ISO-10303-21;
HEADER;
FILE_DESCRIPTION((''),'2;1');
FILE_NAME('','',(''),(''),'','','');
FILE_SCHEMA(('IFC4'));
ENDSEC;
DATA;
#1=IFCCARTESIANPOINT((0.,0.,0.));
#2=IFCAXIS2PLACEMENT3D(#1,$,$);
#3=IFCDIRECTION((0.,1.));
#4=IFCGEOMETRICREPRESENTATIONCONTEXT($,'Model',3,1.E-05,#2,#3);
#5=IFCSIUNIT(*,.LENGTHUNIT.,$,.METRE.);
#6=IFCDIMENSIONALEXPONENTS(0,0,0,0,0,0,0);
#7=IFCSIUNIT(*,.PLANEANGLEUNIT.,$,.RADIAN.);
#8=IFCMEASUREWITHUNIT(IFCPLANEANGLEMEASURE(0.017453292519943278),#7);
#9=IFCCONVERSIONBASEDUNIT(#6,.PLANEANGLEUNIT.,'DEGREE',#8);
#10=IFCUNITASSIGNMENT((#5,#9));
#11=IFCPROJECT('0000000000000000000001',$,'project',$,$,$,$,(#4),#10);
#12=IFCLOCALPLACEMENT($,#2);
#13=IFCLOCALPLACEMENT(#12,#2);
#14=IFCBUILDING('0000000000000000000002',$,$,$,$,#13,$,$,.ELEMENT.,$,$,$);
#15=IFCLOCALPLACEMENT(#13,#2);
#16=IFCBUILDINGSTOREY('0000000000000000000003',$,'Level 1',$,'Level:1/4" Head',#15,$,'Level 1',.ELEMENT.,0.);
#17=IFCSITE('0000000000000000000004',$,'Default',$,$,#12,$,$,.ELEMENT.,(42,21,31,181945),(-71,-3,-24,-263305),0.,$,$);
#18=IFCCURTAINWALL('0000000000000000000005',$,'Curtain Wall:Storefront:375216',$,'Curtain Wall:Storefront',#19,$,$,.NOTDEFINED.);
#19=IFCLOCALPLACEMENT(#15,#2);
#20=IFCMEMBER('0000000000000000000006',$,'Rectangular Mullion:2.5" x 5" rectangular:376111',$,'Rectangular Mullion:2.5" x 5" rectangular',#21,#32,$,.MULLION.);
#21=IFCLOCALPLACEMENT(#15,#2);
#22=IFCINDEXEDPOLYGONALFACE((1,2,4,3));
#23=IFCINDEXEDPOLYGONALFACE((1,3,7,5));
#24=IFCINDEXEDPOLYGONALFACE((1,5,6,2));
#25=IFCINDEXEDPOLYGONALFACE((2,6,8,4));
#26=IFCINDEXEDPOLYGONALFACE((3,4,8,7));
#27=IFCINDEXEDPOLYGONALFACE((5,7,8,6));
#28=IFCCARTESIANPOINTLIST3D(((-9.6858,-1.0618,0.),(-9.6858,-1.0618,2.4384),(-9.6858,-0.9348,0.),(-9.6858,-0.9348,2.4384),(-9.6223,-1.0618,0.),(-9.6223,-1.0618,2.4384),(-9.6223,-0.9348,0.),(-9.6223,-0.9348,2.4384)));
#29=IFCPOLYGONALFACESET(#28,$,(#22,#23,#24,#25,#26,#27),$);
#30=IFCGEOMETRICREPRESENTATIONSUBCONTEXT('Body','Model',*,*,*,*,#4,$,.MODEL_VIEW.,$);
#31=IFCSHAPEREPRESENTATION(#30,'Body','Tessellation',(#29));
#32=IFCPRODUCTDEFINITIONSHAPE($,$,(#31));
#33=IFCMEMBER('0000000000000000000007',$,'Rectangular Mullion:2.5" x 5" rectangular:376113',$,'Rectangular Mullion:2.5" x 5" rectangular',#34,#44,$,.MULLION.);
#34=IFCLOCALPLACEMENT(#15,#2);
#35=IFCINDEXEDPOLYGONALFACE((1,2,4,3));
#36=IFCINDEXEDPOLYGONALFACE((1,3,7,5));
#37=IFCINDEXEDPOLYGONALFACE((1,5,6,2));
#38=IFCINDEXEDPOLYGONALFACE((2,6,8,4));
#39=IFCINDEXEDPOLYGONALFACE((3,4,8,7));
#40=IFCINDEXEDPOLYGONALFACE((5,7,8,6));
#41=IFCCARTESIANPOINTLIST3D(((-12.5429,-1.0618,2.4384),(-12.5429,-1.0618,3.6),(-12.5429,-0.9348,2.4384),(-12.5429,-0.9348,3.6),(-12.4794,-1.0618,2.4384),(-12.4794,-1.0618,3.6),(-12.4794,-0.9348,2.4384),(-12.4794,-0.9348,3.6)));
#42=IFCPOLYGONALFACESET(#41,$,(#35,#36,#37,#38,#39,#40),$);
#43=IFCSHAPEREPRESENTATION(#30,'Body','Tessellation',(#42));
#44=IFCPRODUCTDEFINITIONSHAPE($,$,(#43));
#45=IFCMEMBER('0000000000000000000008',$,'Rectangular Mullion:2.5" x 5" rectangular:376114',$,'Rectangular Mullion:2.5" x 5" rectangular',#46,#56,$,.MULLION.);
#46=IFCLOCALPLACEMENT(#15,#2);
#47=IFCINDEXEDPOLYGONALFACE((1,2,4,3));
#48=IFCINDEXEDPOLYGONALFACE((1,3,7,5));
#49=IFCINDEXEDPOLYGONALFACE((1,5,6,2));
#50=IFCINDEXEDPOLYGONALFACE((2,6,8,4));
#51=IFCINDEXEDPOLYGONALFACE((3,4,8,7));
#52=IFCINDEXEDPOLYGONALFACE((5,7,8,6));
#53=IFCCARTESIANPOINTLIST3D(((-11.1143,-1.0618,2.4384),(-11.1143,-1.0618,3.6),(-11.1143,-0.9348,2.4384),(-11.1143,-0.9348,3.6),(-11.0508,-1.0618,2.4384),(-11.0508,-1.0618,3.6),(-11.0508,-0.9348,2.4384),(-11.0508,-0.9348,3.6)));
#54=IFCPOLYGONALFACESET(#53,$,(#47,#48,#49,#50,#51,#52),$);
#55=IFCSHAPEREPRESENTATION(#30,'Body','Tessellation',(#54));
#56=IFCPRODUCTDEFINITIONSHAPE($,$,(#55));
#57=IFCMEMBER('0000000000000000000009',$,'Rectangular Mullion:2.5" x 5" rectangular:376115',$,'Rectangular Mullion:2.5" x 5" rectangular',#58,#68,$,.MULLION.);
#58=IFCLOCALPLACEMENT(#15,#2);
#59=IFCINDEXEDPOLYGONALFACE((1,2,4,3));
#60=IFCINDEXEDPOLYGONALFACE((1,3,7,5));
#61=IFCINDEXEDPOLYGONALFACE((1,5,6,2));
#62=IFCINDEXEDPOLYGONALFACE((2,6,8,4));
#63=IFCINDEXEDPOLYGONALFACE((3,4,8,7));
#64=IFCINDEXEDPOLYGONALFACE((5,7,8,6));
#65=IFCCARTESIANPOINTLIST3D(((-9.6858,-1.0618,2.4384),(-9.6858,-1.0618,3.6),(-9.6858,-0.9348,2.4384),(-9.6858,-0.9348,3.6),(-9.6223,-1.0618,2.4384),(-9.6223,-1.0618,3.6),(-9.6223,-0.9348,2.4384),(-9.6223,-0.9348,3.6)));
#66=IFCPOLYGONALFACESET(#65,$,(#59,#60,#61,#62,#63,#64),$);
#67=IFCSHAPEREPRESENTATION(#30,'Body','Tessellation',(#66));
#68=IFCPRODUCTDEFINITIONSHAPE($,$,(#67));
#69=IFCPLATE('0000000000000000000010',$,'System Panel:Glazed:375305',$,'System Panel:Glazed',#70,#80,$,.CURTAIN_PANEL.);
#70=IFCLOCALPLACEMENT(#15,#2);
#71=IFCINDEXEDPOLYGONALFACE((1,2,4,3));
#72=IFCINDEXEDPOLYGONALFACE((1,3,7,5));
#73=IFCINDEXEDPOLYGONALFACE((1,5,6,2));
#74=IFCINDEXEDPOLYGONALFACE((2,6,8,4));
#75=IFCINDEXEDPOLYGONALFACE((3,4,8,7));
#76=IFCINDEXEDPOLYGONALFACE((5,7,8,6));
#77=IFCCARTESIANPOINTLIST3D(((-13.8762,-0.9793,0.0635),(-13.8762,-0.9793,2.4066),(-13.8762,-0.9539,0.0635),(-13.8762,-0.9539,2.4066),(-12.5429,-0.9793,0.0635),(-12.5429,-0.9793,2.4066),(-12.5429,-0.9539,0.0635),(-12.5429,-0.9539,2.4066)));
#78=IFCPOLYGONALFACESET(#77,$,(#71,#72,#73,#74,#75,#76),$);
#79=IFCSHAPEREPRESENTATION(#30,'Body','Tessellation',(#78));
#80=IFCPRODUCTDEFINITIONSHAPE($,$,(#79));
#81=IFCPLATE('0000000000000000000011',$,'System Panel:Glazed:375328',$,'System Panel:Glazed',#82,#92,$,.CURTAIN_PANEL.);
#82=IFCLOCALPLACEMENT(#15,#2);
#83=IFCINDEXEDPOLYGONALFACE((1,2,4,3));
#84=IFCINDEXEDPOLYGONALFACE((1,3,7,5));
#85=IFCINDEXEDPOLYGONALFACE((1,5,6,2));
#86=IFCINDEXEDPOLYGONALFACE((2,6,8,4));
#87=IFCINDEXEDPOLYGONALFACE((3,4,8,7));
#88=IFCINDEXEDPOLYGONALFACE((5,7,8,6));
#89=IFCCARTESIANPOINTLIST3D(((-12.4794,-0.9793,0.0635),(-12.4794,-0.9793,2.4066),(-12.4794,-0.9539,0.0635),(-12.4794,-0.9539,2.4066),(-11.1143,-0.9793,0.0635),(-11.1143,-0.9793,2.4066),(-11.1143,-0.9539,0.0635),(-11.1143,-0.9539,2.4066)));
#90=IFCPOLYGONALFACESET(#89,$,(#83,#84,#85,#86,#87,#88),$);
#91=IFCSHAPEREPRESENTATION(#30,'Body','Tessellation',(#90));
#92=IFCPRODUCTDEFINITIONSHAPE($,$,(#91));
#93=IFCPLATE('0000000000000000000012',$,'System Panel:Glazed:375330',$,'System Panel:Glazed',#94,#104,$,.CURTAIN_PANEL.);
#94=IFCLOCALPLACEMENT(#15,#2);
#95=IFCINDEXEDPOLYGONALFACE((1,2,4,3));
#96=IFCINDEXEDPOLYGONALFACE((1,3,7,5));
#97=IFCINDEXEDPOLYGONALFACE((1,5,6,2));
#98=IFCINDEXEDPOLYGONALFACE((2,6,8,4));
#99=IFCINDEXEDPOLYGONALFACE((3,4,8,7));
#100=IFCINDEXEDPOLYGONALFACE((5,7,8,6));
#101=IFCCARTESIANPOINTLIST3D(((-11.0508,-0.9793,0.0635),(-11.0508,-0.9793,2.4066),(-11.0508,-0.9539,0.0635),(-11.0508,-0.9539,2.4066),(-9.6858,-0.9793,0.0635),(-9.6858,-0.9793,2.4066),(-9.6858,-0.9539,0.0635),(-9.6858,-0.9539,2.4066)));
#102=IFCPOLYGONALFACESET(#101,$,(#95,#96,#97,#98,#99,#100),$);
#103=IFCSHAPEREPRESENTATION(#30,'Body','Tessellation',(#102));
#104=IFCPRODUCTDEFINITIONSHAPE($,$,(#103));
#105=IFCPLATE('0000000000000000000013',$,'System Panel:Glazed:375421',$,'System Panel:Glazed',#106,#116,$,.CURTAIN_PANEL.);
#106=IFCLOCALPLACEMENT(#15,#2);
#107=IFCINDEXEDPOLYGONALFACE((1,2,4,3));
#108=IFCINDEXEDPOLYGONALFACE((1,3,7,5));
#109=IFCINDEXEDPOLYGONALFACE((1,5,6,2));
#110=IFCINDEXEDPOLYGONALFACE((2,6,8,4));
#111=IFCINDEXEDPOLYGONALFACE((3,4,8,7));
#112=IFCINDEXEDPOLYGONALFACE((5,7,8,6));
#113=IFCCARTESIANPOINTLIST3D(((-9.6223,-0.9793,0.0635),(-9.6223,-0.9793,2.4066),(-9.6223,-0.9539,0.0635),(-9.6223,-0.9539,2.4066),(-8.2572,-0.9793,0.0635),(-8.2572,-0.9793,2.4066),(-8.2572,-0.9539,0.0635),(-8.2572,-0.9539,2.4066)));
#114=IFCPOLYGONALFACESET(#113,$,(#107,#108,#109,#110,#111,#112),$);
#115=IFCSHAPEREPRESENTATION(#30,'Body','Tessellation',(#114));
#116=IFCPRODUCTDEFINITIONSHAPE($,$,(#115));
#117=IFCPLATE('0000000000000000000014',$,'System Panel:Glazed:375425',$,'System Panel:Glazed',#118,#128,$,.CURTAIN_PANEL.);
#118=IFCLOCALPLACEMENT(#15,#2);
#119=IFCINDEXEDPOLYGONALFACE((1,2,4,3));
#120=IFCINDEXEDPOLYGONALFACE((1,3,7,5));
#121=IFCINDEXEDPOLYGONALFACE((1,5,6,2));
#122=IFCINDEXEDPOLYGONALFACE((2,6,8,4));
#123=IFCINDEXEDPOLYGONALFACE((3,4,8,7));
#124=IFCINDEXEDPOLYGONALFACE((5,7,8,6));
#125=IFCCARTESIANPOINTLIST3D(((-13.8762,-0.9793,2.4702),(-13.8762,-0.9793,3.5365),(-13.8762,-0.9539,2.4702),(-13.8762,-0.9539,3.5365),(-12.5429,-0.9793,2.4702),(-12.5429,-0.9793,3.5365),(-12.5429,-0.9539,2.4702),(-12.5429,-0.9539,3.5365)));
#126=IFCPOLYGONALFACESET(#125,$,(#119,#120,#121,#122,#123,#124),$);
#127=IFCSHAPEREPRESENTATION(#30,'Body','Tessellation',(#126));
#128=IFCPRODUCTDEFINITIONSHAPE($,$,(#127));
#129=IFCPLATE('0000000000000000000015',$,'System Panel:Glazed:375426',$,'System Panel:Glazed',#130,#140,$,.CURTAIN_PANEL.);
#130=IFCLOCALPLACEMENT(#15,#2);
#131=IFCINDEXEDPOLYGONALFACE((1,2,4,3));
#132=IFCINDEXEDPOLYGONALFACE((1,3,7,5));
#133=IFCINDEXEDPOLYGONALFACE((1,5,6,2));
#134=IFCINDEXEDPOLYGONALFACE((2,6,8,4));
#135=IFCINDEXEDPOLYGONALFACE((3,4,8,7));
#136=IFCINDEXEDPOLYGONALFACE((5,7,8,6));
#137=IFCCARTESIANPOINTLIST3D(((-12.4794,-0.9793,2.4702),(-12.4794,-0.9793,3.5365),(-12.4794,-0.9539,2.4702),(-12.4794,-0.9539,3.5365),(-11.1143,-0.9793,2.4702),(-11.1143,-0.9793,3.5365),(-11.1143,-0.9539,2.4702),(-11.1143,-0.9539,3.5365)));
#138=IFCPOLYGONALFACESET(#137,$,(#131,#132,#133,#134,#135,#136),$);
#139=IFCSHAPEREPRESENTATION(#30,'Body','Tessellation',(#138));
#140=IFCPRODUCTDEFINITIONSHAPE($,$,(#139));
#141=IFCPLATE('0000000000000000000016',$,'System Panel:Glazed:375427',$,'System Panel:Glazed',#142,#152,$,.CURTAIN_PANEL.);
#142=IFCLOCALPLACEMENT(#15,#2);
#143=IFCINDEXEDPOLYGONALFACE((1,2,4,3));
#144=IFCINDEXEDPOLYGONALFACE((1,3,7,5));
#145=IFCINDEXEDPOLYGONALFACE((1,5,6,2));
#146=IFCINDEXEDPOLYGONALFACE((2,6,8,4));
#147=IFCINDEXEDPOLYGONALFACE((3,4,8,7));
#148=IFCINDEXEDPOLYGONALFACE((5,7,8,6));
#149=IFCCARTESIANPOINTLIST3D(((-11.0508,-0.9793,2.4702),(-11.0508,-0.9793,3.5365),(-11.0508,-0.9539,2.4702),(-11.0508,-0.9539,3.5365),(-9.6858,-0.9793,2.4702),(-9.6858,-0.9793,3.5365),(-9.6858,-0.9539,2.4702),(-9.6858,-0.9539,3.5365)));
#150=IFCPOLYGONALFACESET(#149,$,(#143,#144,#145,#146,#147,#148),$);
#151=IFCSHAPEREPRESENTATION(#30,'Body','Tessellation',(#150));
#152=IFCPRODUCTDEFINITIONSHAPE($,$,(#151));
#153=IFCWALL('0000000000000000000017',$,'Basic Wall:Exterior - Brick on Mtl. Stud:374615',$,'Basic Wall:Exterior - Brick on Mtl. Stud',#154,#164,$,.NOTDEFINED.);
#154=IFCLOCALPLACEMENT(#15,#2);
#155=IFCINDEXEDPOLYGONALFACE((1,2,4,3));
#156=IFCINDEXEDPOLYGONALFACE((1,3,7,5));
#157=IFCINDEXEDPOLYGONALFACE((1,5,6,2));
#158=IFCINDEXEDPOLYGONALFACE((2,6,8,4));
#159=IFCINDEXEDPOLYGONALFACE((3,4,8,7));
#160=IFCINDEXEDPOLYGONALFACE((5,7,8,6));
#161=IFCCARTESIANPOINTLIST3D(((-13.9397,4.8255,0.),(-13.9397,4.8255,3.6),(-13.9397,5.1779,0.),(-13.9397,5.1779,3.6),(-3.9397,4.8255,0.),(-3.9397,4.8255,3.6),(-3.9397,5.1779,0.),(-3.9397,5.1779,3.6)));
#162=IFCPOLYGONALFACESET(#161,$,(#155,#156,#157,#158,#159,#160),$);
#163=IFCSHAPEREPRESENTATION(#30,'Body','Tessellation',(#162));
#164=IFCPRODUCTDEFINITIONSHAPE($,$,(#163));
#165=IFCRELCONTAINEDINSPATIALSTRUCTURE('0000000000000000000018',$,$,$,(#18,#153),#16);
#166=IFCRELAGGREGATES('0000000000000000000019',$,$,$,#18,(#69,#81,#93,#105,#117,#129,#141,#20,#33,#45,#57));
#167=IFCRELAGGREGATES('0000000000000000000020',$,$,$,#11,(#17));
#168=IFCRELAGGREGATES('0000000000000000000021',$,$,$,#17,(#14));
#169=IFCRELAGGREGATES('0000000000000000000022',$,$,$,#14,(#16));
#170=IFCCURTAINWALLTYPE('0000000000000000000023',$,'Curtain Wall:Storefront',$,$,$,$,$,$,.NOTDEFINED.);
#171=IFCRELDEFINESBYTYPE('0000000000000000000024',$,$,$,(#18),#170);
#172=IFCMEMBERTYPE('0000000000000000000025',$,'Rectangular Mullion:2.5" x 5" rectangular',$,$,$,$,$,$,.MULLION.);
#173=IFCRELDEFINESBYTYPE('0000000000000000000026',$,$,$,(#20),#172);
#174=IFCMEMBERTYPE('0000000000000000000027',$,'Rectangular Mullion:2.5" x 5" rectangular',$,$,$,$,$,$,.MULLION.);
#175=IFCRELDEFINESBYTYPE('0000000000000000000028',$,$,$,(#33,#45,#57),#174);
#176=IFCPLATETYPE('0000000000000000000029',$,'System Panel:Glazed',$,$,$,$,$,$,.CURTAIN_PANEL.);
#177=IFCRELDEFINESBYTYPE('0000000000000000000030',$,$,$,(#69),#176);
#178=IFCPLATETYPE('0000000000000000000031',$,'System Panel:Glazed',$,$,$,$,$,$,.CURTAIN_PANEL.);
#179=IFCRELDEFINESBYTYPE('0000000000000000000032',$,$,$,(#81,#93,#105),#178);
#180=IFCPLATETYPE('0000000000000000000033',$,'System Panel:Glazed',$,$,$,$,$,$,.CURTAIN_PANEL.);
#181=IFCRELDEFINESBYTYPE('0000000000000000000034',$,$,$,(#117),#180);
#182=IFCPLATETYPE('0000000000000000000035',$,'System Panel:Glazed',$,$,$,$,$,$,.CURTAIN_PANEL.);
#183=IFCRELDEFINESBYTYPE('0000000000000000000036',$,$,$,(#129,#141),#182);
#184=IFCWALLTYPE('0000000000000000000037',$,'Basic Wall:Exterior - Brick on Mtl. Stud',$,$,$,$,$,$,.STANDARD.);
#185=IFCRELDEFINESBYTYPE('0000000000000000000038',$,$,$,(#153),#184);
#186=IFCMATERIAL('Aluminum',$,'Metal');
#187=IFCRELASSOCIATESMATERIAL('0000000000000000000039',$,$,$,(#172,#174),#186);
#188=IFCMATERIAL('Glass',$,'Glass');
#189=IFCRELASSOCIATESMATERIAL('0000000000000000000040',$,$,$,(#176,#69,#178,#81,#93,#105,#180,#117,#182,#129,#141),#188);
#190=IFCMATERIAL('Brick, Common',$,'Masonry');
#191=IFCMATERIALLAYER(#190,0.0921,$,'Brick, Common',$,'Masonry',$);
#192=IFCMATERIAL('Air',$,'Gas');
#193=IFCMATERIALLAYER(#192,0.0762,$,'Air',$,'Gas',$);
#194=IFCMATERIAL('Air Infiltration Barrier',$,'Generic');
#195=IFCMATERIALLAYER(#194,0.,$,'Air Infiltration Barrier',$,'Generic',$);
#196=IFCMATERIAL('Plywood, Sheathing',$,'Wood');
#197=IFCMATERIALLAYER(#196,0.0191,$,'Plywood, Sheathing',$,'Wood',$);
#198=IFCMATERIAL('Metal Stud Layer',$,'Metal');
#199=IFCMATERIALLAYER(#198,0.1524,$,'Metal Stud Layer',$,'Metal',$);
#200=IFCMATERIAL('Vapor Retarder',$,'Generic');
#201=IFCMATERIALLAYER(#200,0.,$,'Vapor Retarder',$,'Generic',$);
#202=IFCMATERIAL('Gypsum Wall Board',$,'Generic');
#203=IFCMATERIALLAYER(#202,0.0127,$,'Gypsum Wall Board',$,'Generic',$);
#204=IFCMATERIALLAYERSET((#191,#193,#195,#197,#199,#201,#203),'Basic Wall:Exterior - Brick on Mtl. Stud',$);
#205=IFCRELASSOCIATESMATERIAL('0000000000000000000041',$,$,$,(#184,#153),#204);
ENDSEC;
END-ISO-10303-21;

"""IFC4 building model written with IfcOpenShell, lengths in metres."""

from ifc_helpers import new_model, entity, si_unit, converted_unit, direction, frame, frame_2d, origin, origin_2d_with_axis, place, context, subcontext, project, spatial, rectangle, extrude, source, transform, mapped, material, layer, layer_set, layer_usage, material_profile, profile_set, type_object, type_shapes, element, aggregate, save


model = new_model("IFC4")

# Units and contexts
model_context = context("Model", 3, precision=1e-05, world=origin(), true_north=direction((0.0, 1.0)))
body_context = subcontext(model_context, "Body", "Model", "MODEL_VIEW")
ifc_project = project(units=[si_unit("LENGTHUNIT", "METRE"), converted_unit("PLANEANGLEUNIT", "DEGREE", entity("IfcPlaneAngleMeasure", 0.017453292519943278), si_unit("PLANEANGLEUNIT", "RADIAN"), dimensions=[0, 0, 0, 0, 0, 0, 0])], contexts=[model_context])

# Site, building, storey
site_placement = place(None, origin())
site = spatial("IfcSite", under=ifc_project, at=site_placement, Name="Default", CompositionType="ELEMENT", RefLatitude=(42, 21, 31, 181945), RefLongitude=(-71, -3, -24, -263305), RefElevation=0.0)
building_placement = place(site_placement, origin())
building = spatial("IfcBuilding", under=site, at=building_placement, CompositionType="ELEMENT")
storey_placement = place(building_placement, origin())
storey = spatial("IfcBuildingStorey", under=building, at=storey_placement, Name="Level 1", ObjectType="Level:1/4\" Head", LongName="Level 1", CompositionType="ELEMENT", Elevation=0.0)

# Curtain wall, members, plates
curtain_wall_type = type_object("IfcCurtainWallType", Name="Curtain Wall:Storefront", PredefinedType="NOTDEFINED")
curtain_wall_placement = place(storey_placement, origin())
curtain_wall = element("IfcCurtainWall", 1, at=curtain_wall_placement, inside=storey, type_object=curtain_wall_type, Name="Curtain Wall:Storefront:375216", ObjectType="Curtain Wall:Storefront", PredefinedType="NOTDEFINED")
ifc_material_1 = material(Name="Aluminum", Category="Metal")
ifc_material_profile = material_profile(ifc_material_1, rectangle(XDim=0.0635, YDim=0.127, at=frame_2d((0.0, 0.0), x_axis=(1.0, 0.0))), Name="2.5\" x 5\" rectangular")
ifc_profile_set = profile_set([ifc_material_profile], Name="2.5\" x 5\" rectangular")
member_type_1 = type_object("IfcMemberType", Name="Rectangular Mullion:2.5\" x 5\" rectangular", PredefinedType="MULLION", material=ifc_profile_set)
shared_shape_1 = source(origin(), body_context, "Body", "SweptSolid", [
    extrude(rectangle(XDim=0.0635, YDim=0.127, at=origin_2d_with_axis()), frame((0.0, 0.0, -2.4384), z_axis=(0.0, 0.0, 1.0), x_axis=(-1.0, 0.0, 0.0)), (0.0, 0.0, 1.0), 2.4384),
])
type_shapes(member_type_1, [shared_shape_1])
member_1_placement = place(curtain_wall_placement, frame((-9.654, -0.9983, 0.0), z_axis=(0.0, 0.0, -1.0), x_axis=(1.0, 0.0, 0.0)))
member_1 = element("IfcMember", 2, at=member_1_placement, type_object=member_type_1, Name="Rectangular Mullion:2.5\" x 5\" rectangular:376111", ObjectType="Rectangular Mullion:2.5\" x 5\" rectangular", PredefinedType="MULLION", context=body_context, shape_type="MappedRepresentation", body=[
    mapped(shared_shape_1, transform((0.0, 0.0, 0.0), scale=1.0)),
])
member_type_2 = type_object("IfcMemberType", Name="Rectangular Mullion:2.5\" x 5\" rectangular", PredefinedType="MULLION", material=ifc_profile_set)
shared_shape_2 = source(origin(), body_context, "Body", "SweptSolid", [
    extrude(rectangle(XDim=0.0635, YDim=0.127, at=origin_2d_with_axis()), frame((0.0, 0.0, -1.1616), z_axis=(0.0, 0.0, 1.0), x_axis=(-1.0, 0.0, 0.0)), (0.0, 0.0, 1.0), 1.1616),
])
type_shapes(member_type_2, [shared_shape_2])
member_2_placement = place(curtain_wall_placement, frame((-12.5112, -0.9983, 2.4384), z_axis=(0.0, 0.0, -1.0), x_axis=(1.0, 0.0, 0.0)))
member_2 = element("IfcMember", 3, at=member_2_placement, type_object=member_type_2, Name="Rectangular Mullion:2.5\" x 5\" rectangular:376113", ObjectType="Rectangular Mullion:2.5\" x 5\" rectangular", PredefinedType="MULLION", context=body_context, shape_type="MappedRepresentation", body=[
    mapped(shared_shape_2, transform((0.0, 0.0, 0.0), scale=1.0)),
])
member_3_placement = place(curtain_wall_placement, frame((-11.0826, -0.9983, 2.4384), z_axis=(0.0, 0.0, -1.0), x_axis=(1.0, 0.0, 0.0)))
member_3 = element("IfcMember", 4, at=member_3_placement, type_object=member_type_2, Name="Rectangular Mullion:2.5\" x 5\" rectangular:376114", ObjectType="Rectangular Mullion:2.5\" x 5\" rectangular", PredefinedType="MULLION", context=body_context, shape_type="MappedRepresentation", body=[
    mapped(shared_shape_2, transform((0.0, 0.0, 0.0), scale=1.0)),
])
member_4_placement = place(curtain_wall_placement, frame((-9.654, -0.9983, 2.4384), z_axis=(0.0, 0.0, -1.0), x_axis=(1.0, 0.0, 0.0)))
member_4 = element("IfcMember", 5, at=member_4_placement, type_object=member_type_2, Name="Rectangular Mullion:2.5\" x 5\" rectangular:376115", ObjectType="Rectangular Mullion:2.5\" x 5\" rectangular", PredefinedType="MULLION", context=body_context, shape_type="MappedRepresentation", body=[
    mapped(shared_shape_2, transform((0.0, 0.0, 0.0), scale=1.0)),
])
ifc_material_2 = material(Name="Glass", Category="Glass")
plate_type_1 = type_object("IfcPlateType", Name="System Panel:Glazed", PredefinedType="CURTAIN_PANEL", material=ifc_material_2)
shared_shape_3 = source(origin(), body_context, "Body", "SweptSolid", [
    extrude(rectangle(XDim=0.0254, YDim=1.3333, at=frame_2d((0.0, 0.0), x_axis=(1.0, 0.0))), frame((0.6667, 0.0127, 0.0), z_axis=(0.0, 0.0, 1.0), x_axis=(0.0, 1.0, 0.0)), (0.0, 0.0, 1.0), 2.3432),
])
type_shapes(plate_type_1, [shared_shape_3])
plate_1_placement = place(curtain_wall_placement, frame((-13.8762, -0.9793, 0.0635)))
plate_1 = element("IfcPlate", 6, at=plate_1_placement, type_object=plate_type_1, material=ifc_material_2, Name="System Panel:Glazed:375305", ObjectType="System Panel:Glazed", PredefinedType="CURTAIN_PANEL", context=body_context, shape_type="MappedRepresentation", body=[
    mapped(shared_shape_3, transform((0.0, 0.0, 0.0), scale=1.0)),
])
plate_type_2 = type_object("IfcPlateType", Name="System Panel:Glazed", PredefinedType="CURTAIN_PANEL", material=ifc_material_2)
shared_shape_4 = source(origin(), body_context, "Body", "SweptSolid", [
    extrude(rectangle(XDim=0.0254, YDim=1.3651, at=frame_2d((0.0, 0.0), x_axis=(1.0, 0.0))), frame((0.6825, 0.0127, 0.0), z_axis=(0.0, 0.0, 1.0), x_axis=(0.0, 1.0, 0.0)), (0.0, 0.0, 1.0), 2.3432),
])
type_shapes(plate_type_2, [shared_shape_4])
plate_2_placement = place(curtain_wall_placement, frame((-12.4794, -0.9793, 0.0635)))
plate_2 = element("IfcPlate", 7, at=plate_2_placement, type_object=plate_type_2, material=ifc_material_2, Name="System Panel:Glazed:375328", ObjectType="System Panel:Glazed", PredefinedType="CURTAIN_PANEL", context=body_context, shape_type="MappedRepresentation", body=[
    mapped(shared_shape_4, transform((0.0, 0.0, 0.0), scale=1.0)),
])
plate_3_placement = place(curtain_wall_placement, frame((-11.0508, -0.9793, 0.0635)))
plate_3 = element("IfcPlate", 8, at=plate_3_placement, type_object=plate_type_2, material=ifc_material_2, Name="System Panel:Glazed:375330", ObjectType="System Panel:Glazed", PredefinedType="CURTAIN_PANEL", context=body_context, shape_type="MappedRepresentation", body=[
    mapped(shared_shape_4, transform((0.0, 0.0, 0.0), scale=1.0)),
])
plate_4_placement = place(curtain_wall_placement, frame((-9.6223, -0.9793, 0.0635)))
plate_4 = element("IfcPlate", 9, at=plate_4_placement, type_object=plate_type_2, material=ifc_material_2, Name="System Panel:Glazed:375421", ObjectType="System Panel:Glazed", PredefinedType="CURTAIN_PANEL", context=body_context, shape_type="MappedRepresentation", body=[
    mapped(shared_shape_4, transform((0.0, 0.0, 0.0), scale=1.0)),
])
plate_type_3 = type_object("IfcPlateType", Name="System Panel:Glazed", PredefinedType="CURTAIN_PANEL", material=ifc_material_2)
shared_shape_5 = source(origin(), body_context, "Body", "SweptSolid", [
    extrude(rectangle(XDim=0.0254, YDim=1.3333, at=frame_2d((0.0, 0.0), x_axis=(1.0, 0.0))), frame((0.6667, 0.0127, 0.0), z_axis=(0.0, 0.0, 1.0), x_axis=(0.0, 1.0, 0.0)), (0.0, 0.0, 1.0), 1.0663),
])
type_shapes(plate_type_3, [shared_shape_5])
plate_5_placement = place(curtain_wall_placement, frame((-13.8762, -0.9793, 2.4701)))
plate_5 = element("IfcPlate", 10, at=plate_5_placement, type_object=plate_type_3, material=ifc_material_2, Name="System Panel:Glazed:375425", ObjectType="System Panel:Glazed", PredefinedType="CURTAIN_PANEL", context=body_context, shape_type="MappedRepresentation", body=[
    mapped(shared_shape_5, transform((0.0, 0.0, 0.0), scale=1.0)),
])
plate_type_4 = type_object("IfcPlateType", Name="System Panel:Glazed", PredefinedType="CURTAIN_PANEL", material=ifc_material_2)
shared_shape_6 = source(origin(), body_context, "Body", "SweptSolid", [
    extrude(rectangle(XDim=0.0254, YDim=1.3651, at=frame_2d((0.0, 0.0), x_axis=(1.0, 0.0))), frame((0.6825, 0.0127, 0.0), z_axis=(0.0, 0.0, 1.0), x_axis=(0.0, 1.0, 0.0)), (0.0, 0.0, 1.0), 1.0663),
])
type_shapes(plate_type_4, [shared_shape_6])
plate_6_placement = place(curtain_wall_placement, frame((-12.4794, -0.9793, 2.4701)))
plate_6 = element("IfcPlate", 11, at=plate_6_placement, type_object=plate_type_4, material=ifc_material_2, Name="System Panel:Glazed:375426", ObjectType="System Panel:Glazed", PredefinedType="CURTAIN_PANEL", context=body_context, shape_type="MappedRepresentation", body=[
    mapped(shared_shape_6, transform((0.0, 0.0, 0.0), scale=1.0)),
])
plate_7_placement = place(curtain_wall_placement, frame((-11.0508, -0.9793, 2.4701)))
plate_7 = element("IfcPlate", 12, at=plate_7_placement, type_object=plate_type_4, material=ifc_material_2, Name="System Panel:Glazed:375427", ObjectType="System Panel:Glazed", PredefinedType="CURTAIN_PANEL", context=body_context, shape_type="MappedRepresentation", body=[
    mapped(shared_shape_6, transform((0.0, 0.0, 0.0), scale=1.0)),
])
aggregate(curtain_wall, [plate_1, plate_2, plate_3, plate_4, plate_5, plate_6, plate_7, member_1, member_2, member_3, member_4])

# Wall
ifc_material_3 = material(Name="Brick, Common", Category="Masonry")
ifc_layer_1 = layer(ifc_material_3, 0.0921, Name="Brick, Common", Category="Masonry")
ifc_material_4 = material(Name="Air", Category="Gas")
ifc_layer_2 = layer(ifc_material_4, 0.0762, Name="Air", Category="Gas")
ifc_material_5 = material(Name="Air Infiltration Barrier", Category="Generic")
ifc_layer_3 = layer(ifc_material_5, 0.0, Name="Air Infiltration Barrier", Category="Generic")
ifc_material_6 = material(Name="Plywood, Sheathing", Category="Wood")
ifc_layer_4 = layer(ifc_material_6, 0.0191, Name="Plywood, Sheathing", Category="Wood")
ifc_material_7 = material(Name="Metal Stud Layer", Category="Metal")
ifc_layer_5 = layer(ifc_material_7, 0.1524, Name="Metal Stud Layer", Category="Metal")
ifc_material_8 = material(Name="Vapor Retarder", Category="Generic")
ifc_layer_6 = layer(ifc_material_8, 0.0, Name="Vapor Retarder", Category="Generic")
ifc_material_9 = material(Name="Gypsum Wall Board", Category="Generic")
ifc_layer_7 = layer(ifc_material_9, 0.0127, Name="Gypsum Wall Board", Category="Generic")
ifc_layer_set_1 = layer_set([ifc_layer_1, ifc_layer_2, ifc_layer_3, ifc_layer_4, ifc_layer_5, ifc_layer_6, ifc_layer_7], Name="Basic Wall:Exterior - Brick on Mtl. Stud")
ifc_layer_usage_1 = layer_usage(ifc_layer_set_1, "AXIS2", "NEGATIVE", 0.1762)
wall_type_1 = type_object("IfcWallType", Name="Basic Wall:Exterior - Brick on Mtl. Stud", PredefinedType="STANDARD", material=ifc_layer_set_1)
wall_1_placement = place(storey_placement, frame((-13.9397, 5.0017, 0.0)))
element("IfcWall", 13, at=wall_1_placement, inside=storey, type_object=wall_type_1, material=ifc_layer_usage_1, Name="Basic Wall:Exterior - Brick on Mtl. Stud:374615", ObjectType="Basic Wall:Exterior - Brick on Mtl. Stud", PredefinedType="NOTDEFINED", context=body_context, shape_type="SweptSolid", body=[
    extrude(rectangle(XDim=10.0, YDim=0.3524, at=frame_2d((5.0, 0.0), x_axis=(-1.0, 0.0))), origin(), (0.0, 0.0, 1.0), 3.6),
])

save(model, "model.ifc")
